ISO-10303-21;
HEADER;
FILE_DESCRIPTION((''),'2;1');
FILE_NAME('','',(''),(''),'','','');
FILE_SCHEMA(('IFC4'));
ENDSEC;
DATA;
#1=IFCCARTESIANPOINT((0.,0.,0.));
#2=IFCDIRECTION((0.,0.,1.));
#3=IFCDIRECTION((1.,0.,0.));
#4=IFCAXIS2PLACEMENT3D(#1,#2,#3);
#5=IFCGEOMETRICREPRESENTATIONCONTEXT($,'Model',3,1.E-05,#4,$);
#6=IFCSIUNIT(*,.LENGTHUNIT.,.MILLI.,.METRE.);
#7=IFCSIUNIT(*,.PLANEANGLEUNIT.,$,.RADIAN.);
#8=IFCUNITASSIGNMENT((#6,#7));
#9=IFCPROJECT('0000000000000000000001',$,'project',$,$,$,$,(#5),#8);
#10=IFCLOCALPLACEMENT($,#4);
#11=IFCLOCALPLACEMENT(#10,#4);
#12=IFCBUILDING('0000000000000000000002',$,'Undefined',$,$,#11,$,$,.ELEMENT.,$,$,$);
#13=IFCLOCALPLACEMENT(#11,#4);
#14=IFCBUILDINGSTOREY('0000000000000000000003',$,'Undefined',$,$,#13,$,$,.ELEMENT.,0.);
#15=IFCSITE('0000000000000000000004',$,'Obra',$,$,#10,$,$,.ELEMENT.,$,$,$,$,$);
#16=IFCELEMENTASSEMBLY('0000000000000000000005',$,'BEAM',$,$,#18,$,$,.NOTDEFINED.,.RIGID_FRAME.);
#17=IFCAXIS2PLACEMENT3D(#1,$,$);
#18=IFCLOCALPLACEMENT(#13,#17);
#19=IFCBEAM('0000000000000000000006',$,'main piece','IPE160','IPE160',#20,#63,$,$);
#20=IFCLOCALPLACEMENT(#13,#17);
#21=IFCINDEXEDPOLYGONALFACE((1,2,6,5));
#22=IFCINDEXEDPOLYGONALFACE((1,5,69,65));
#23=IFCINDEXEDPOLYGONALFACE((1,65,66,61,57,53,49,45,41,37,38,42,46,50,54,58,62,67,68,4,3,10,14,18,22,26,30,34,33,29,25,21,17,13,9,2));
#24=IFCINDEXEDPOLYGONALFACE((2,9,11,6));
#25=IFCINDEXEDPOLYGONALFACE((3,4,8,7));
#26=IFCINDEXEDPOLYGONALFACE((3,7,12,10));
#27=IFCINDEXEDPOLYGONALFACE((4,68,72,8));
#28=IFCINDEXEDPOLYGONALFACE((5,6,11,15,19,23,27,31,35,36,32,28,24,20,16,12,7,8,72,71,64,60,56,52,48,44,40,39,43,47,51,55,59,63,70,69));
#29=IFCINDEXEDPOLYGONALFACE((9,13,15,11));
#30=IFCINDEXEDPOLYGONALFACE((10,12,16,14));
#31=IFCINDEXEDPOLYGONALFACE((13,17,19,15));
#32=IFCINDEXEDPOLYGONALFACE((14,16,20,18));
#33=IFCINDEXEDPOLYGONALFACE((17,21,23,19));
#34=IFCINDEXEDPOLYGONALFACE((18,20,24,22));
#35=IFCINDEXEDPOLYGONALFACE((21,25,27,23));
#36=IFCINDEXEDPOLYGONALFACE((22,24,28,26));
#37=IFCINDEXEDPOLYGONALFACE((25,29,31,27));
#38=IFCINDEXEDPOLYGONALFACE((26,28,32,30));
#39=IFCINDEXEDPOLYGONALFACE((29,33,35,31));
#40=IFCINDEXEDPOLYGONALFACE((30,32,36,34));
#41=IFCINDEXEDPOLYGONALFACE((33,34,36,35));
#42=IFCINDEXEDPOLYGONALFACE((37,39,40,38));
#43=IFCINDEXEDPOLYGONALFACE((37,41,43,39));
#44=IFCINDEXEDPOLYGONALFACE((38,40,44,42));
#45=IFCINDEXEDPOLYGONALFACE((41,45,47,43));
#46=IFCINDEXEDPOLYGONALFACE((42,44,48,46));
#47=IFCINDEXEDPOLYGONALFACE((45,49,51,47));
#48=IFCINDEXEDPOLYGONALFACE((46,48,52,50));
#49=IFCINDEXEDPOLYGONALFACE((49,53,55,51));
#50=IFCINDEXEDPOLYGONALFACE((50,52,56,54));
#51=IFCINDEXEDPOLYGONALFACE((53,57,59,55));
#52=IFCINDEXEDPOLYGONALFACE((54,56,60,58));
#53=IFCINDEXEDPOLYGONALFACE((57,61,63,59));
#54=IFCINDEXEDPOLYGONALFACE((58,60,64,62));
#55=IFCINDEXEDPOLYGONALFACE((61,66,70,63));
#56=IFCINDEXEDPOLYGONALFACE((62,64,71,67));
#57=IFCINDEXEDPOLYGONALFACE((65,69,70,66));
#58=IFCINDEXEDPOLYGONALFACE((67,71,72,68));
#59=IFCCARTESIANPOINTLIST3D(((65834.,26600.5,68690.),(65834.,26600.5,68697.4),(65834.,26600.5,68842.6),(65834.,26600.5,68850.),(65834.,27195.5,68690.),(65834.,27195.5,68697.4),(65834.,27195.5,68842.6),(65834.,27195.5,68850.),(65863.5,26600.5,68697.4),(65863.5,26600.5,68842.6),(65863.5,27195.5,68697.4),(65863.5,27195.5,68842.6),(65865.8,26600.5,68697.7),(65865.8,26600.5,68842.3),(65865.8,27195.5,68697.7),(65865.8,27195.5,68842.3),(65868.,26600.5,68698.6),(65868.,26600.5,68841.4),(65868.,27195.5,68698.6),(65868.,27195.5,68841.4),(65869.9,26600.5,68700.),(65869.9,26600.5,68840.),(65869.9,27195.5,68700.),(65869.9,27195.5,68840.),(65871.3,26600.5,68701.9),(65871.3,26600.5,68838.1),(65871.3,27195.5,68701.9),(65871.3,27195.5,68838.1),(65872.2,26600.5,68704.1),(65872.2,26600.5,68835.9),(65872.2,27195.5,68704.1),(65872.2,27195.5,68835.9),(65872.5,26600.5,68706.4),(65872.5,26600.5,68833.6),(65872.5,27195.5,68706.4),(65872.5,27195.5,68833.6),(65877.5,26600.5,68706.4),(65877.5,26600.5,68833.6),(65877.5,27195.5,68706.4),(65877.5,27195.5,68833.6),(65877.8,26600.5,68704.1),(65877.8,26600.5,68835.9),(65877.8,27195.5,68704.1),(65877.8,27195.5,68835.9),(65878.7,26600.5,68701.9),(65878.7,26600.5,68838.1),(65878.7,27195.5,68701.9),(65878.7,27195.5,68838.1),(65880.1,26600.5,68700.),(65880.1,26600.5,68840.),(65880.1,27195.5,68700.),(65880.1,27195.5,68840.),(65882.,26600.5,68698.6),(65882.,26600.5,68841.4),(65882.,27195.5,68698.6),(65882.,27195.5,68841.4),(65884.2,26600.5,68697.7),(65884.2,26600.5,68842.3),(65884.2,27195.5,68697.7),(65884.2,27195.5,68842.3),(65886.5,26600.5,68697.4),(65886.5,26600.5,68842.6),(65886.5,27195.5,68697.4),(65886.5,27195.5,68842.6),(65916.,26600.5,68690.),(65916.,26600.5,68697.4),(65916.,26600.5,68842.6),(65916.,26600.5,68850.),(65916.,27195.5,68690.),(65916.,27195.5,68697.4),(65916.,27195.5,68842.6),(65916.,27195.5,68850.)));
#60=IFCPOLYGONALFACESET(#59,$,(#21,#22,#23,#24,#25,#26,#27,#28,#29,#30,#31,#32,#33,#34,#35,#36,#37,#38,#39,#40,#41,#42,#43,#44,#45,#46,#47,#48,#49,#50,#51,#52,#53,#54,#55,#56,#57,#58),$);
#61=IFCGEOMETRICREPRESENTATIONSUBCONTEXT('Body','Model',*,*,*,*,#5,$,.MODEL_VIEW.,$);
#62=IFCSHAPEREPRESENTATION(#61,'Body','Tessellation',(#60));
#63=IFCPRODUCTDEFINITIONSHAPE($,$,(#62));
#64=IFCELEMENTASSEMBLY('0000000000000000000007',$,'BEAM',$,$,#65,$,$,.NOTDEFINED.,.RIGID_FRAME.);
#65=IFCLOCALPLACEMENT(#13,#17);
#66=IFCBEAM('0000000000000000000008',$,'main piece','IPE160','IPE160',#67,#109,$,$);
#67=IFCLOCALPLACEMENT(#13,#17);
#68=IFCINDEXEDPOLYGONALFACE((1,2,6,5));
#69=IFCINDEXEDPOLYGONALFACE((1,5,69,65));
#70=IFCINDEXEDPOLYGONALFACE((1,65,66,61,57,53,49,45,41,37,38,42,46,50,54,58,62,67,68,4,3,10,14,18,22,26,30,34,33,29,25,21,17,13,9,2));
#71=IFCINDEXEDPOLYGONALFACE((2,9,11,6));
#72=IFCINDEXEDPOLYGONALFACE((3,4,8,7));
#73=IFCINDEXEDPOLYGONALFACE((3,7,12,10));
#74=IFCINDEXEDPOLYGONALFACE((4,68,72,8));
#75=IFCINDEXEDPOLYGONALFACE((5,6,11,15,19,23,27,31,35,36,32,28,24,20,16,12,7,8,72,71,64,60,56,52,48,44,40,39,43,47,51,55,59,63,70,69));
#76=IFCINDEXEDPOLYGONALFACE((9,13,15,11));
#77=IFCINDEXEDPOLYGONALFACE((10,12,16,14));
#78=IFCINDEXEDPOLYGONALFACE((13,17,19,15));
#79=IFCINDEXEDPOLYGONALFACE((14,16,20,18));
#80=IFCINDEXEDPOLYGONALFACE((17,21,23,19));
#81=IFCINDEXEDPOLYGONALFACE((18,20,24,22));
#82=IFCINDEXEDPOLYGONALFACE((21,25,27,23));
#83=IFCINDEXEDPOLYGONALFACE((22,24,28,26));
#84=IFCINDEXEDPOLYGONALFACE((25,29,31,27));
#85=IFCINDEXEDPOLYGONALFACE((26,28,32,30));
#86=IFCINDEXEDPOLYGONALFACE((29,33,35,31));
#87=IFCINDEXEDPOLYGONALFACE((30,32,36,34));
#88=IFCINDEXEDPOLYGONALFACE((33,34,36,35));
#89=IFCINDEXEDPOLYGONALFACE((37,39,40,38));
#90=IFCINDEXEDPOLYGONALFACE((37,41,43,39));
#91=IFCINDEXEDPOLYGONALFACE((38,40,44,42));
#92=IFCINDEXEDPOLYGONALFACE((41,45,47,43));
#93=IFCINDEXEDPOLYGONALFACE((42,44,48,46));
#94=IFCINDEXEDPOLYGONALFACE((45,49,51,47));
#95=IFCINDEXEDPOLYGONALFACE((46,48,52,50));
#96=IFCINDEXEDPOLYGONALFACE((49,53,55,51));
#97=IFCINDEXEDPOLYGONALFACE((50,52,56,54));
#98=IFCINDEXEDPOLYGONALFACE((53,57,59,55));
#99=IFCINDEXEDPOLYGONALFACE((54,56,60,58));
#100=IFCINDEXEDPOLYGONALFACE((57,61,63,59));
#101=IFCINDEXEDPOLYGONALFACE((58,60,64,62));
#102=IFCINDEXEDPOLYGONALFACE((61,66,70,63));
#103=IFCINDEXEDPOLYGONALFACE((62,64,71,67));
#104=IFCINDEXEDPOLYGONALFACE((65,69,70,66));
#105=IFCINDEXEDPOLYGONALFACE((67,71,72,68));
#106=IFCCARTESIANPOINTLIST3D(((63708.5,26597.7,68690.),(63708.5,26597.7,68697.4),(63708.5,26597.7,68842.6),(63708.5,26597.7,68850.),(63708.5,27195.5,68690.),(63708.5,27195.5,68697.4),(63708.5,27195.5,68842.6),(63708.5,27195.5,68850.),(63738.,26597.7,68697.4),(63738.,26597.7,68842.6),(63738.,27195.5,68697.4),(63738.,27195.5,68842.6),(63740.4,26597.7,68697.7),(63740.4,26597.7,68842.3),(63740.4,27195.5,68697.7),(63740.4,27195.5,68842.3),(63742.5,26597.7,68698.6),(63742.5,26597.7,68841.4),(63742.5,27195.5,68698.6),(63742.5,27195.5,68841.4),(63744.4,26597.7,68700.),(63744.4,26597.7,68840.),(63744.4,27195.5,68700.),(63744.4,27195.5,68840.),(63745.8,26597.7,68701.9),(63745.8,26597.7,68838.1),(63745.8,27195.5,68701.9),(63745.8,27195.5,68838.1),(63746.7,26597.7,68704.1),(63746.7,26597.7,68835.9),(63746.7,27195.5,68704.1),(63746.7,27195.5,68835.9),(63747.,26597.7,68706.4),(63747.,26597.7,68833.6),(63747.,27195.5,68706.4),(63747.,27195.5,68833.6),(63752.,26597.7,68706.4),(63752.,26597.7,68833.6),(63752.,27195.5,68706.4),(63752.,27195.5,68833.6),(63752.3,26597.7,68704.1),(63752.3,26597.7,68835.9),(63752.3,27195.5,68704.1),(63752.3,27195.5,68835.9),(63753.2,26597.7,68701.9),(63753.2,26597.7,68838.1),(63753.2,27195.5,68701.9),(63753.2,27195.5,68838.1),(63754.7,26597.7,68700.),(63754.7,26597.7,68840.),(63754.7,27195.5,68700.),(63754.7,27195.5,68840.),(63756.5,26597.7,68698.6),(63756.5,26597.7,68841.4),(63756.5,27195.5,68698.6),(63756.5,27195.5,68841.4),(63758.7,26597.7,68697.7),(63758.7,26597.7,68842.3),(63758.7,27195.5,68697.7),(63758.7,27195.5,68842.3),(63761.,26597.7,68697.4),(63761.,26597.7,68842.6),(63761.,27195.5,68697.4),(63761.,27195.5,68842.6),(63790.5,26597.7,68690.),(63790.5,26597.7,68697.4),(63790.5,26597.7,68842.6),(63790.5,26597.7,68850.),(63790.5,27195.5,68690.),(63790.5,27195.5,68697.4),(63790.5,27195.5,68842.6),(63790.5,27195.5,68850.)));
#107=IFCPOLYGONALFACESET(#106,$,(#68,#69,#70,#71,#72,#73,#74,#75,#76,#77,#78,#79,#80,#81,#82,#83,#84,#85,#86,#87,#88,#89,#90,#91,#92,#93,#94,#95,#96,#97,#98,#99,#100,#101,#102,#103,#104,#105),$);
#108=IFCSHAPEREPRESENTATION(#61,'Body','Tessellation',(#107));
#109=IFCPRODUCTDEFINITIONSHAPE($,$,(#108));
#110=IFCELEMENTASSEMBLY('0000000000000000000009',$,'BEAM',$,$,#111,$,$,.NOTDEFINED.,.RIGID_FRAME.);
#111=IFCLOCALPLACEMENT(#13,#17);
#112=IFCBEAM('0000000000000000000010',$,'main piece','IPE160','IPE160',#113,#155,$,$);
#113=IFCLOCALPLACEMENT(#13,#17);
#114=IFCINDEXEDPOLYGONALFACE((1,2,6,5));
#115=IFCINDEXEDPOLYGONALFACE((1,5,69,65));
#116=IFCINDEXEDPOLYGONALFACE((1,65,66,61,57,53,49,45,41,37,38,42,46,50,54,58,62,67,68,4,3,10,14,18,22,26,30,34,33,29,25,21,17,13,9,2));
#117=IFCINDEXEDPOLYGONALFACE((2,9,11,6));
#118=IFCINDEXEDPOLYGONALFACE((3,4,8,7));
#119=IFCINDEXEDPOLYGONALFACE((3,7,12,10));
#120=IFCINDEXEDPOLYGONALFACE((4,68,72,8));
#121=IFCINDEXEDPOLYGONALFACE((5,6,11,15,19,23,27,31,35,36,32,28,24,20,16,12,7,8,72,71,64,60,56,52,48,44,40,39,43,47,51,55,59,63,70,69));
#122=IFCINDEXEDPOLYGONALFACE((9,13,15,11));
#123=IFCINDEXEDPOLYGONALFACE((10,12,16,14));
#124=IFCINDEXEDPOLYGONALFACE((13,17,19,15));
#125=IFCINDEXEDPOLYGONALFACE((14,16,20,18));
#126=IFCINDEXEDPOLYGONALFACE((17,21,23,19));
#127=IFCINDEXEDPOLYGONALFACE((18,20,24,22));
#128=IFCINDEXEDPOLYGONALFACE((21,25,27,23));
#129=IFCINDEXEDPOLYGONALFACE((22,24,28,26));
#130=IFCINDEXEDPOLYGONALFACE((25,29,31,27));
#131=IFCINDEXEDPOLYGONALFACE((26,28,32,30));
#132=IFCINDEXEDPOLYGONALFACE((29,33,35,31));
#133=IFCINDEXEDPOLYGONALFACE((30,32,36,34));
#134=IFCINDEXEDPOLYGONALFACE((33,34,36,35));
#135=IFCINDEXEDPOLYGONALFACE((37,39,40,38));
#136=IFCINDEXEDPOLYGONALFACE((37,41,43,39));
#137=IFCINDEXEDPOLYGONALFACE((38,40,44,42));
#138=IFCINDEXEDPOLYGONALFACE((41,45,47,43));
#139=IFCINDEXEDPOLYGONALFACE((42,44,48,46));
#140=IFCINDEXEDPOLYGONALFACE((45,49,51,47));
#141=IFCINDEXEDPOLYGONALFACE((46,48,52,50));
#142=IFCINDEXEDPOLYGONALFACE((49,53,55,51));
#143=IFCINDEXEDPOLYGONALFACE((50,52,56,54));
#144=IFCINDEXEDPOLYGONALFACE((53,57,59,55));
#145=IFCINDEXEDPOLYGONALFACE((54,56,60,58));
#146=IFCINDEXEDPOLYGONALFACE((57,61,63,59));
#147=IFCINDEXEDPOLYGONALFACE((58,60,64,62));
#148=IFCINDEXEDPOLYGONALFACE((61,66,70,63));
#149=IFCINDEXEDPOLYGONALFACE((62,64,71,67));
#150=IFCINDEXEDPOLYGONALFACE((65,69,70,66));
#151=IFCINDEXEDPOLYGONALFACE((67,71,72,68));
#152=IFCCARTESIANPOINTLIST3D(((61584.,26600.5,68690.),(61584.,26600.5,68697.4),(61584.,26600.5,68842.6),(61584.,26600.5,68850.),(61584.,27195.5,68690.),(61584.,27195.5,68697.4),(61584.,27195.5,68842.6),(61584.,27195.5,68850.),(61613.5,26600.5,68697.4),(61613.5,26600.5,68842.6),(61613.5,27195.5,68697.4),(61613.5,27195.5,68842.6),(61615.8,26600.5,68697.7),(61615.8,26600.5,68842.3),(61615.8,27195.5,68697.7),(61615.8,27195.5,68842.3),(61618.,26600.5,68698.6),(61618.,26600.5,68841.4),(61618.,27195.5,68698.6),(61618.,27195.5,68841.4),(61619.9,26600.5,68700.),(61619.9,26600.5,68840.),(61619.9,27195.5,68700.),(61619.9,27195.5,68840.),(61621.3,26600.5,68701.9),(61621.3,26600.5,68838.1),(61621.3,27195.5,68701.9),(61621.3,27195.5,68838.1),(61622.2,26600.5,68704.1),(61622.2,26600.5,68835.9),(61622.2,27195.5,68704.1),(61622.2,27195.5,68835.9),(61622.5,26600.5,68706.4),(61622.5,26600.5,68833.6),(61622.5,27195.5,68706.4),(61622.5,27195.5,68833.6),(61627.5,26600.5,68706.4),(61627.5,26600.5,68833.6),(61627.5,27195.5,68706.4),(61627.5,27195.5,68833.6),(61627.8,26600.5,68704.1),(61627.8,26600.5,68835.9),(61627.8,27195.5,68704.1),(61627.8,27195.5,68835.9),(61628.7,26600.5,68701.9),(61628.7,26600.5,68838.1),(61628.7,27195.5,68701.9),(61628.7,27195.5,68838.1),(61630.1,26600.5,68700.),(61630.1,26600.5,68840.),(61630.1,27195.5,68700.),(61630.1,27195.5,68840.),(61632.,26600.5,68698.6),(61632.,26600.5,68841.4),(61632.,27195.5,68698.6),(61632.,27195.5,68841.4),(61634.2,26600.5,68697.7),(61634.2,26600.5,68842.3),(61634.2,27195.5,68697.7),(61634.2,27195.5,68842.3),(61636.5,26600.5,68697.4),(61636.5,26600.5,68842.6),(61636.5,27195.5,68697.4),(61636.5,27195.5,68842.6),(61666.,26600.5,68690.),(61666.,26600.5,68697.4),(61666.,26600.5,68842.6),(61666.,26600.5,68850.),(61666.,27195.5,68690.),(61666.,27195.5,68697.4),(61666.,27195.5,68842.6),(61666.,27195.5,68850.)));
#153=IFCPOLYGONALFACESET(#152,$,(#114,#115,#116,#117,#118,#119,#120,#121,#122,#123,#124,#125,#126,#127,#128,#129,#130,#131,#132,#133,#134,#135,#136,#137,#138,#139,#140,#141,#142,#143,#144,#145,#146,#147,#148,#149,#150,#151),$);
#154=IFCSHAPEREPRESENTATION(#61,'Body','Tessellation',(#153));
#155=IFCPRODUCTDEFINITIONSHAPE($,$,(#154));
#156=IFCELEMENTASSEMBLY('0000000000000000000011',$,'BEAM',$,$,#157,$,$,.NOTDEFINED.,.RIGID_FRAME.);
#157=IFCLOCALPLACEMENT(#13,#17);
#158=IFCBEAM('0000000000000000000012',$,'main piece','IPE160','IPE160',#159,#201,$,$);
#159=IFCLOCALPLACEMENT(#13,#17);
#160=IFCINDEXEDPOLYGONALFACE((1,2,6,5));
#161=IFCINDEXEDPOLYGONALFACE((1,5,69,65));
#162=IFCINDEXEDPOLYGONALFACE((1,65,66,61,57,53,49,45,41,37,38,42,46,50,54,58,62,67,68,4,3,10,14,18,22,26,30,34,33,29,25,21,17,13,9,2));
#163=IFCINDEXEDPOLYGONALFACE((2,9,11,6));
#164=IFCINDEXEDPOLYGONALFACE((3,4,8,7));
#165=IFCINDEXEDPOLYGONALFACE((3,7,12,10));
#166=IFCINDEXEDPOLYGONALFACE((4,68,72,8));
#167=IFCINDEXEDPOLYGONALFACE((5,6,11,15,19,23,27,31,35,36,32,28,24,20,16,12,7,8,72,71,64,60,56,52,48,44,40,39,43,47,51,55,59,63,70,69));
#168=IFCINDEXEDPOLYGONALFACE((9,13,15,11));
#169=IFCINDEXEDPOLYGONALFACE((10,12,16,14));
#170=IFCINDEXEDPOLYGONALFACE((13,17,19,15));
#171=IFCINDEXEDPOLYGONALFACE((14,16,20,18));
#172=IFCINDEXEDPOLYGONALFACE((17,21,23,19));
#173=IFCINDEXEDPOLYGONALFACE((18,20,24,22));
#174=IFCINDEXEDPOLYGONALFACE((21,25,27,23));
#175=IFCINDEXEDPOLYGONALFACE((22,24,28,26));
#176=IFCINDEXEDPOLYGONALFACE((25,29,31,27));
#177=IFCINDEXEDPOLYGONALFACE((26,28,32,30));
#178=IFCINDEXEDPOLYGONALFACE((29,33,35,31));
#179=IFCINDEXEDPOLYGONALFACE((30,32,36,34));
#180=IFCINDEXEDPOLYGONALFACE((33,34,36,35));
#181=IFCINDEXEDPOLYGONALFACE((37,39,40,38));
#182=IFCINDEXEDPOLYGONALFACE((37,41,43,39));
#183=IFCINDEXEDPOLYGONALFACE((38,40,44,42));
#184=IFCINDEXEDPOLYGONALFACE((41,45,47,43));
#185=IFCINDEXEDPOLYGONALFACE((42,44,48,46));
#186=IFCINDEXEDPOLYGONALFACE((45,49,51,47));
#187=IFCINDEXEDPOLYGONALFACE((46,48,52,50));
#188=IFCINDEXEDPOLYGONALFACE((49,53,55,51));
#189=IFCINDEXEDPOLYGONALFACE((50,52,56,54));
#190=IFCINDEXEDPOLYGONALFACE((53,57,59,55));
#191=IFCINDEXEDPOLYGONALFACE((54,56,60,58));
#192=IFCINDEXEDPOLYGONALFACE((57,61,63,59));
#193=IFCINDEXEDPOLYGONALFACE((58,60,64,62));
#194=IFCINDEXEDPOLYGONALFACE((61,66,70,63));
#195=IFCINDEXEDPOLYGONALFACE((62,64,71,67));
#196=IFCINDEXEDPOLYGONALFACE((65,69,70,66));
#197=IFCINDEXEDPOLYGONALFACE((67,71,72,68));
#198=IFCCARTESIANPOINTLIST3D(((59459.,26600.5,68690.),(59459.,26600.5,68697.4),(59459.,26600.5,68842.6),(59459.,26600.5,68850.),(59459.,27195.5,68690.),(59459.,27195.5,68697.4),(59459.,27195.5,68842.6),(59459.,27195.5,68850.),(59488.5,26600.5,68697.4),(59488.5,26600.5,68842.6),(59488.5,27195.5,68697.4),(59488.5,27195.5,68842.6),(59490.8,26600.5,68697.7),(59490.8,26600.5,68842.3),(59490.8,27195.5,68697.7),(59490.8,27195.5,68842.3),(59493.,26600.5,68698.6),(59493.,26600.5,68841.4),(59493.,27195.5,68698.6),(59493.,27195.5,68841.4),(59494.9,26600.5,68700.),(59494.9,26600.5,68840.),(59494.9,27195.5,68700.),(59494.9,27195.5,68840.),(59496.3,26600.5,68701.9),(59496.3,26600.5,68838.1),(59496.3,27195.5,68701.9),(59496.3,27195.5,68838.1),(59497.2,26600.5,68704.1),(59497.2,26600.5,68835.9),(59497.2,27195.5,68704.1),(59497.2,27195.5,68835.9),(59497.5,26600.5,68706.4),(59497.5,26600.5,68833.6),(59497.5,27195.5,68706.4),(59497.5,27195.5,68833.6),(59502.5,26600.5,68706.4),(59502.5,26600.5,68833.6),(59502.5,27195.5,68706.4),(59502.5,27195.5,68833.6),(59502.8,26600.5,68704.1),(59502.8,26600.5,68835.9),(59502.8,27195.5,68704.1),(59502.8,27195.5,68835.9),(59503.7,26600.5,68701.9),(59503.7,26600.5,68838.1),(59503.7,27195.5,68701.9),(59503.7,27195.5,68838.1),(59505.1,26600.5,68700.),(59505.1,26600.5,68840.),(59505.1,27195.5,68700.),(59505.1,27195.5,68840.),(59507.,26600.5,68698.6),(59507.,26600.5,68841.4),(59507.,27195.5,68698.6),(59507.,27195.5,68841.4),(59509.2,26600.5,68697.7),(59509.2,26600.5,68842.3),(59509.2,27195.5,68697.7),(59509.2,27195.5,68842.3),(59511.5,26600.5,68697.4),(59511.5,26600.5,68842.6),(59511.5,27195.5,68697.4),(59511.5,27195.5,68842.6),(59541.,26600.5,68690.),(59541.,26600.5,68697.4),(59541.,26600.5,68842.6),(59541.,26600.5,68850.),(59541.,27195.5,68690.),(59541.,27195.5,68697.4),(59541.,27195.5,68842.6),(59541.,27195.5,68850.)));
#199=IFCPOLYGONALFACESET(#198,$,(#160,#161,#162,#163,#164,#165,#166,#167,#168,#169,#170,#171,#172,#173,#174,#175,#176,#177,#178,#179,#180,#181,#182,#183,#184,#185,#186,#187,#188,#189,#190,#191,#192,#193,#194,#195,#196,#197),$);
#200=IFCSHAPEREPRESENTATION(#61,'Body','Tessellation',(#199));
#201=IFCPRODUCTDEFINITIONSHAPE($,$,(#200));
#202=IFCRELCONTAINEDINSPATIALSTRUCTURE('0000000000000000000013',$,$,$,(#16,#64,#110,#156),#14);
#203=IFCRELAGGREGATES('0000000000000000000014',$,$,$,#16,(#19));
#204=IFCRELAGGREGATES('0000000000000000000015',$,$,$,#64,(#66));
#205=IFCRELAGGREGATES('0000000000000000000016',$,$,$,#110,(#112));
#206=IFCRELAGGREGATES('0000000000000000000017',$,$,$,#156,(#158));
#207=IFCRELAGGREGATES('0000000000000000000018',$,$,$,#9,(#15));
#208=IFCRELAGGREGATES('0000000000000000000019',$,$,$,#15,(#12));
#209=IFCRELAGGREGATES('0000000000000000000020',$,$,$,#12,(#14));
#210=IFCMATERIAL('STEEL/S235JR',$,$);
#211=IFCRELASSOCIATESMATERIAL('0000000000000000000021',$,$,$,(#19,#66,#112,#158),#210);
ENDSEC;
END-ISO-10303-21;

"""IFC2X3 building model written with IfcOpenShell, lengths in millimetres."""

from ifc_helpers import new_model, si_unit, frame, origin_with_axes, origin_2d_with_axis, place, context, subcontext, project, spatial, i_section, extrude, material, element, aggregate, save


model = new_model("IFC2X3")

# Units and contexts
model_context = context("Model", 3, precision=1e-05, world=origin_with_axes())
body_context = subcontext(model_context, "Body", "Model", "MODEL_VIEW")
ifc_project = project(units=[si_unit("LENGTHUNIT", "METRE", prefix="MILLI"), si_unit("PLANEANGLEUNIT", "RADIAN")], contexts=[model_context])

# Site, building, storey
site_placement = place(None, origin_with_axes())
site = spatial("IfcSite", under=ifc_project, at=site_placement, Name="Obra", CompositionType="ELEMENT")
building_placement = place(site_placement, origin_with_axes())
building = spatial("IfcBuilding", under=site, at=building_placement, Name="Undefined", CompositionType="ELEMENT")
storey_placement = place(building_placement, origin_with_axes())
storey = spatial("IfcBuildingStorey", under=building, at=storey_placement, Name="Undefined", CompositionType="ELEMENT", Elevation=0.0)

# Element assemblies, beams
assembly_1_placement = place(storey_placement, origin_with_axes())
assembly_1 = element("IfcElementAssembly", 1, at=assembly_1_placement, inside=storey, Name="BEAM", AssemblyPlace="NOTDEFINED", PredefinedType="RIGID_FRAME")
ifc_material_1 = material(Name="STEEL/S235JR")
beam_1_placement = place(assembly_1_placement, frame((65875.0, 26600.5, 68770.0), z_axis=(0.0, 0.0, 1.0), x_axis=(0.0, 1.0, 0.0)))
beam_1 = element("IfcBeam", 2, at=beam_1_placement, material=ifc_material_1, Name="main piece", Description="IPE160", ObjectType="IPE160", context=body_context, shape_type="SweptSolid", body=[
    extrude(i_section(OverallWidth=82.0, OverallDepth=160.0, WebThickness=5.0, FlangeThickness=7.4, FilletRadius=9.0, at=origin_2d_with_axis()), frame((595.1, 0.0, 0.0), z_axis=(-1.0, 0.0, 0.0), x_axis=(0.0, -1.0, 0.0)), (0.0, 0.0, 1.0), 595.0),
])
aggregate(assembly_1, [beam_1])
assembly_2_placement = place(storey_placement, origin_with_axes())
assembly_2 = element("IfcElementAssembly", 3, at=assembly_2_placement, inside=storey, Name="BEAM", AssemblyPlace="NOTDEFINED", PredefinedType="RIGID_FRAME")
beam_2_placement = place(assembly_2_placement, frame((63749.5, 26597.7, 68770.0), z_axis=(0.0, 0.0, 1.0), x_axis=(0.0, 1.0, 0.0)))
beam_2 = element("IfcBeam", 4, at=beam_2_placement, material=ifc_material_1, Name="main piece", Description="IPE160", ObjectType="IPE160", context=body_context, shape_type="SweptSolid", body=[
    extrude(i_section(OverallWidth=82.0, OverallDepth=160.0, WebThickness=5.0, FlangeThickness=7.4, FilletRadius=9.0, at=origin_2d_with_axis()), frame((597.8, 0.0, 0.0), z_axis=(-1.0, 0.0, 0.0), x_axis=(0.0, -1.0, 0.0)), (0.0, 0.0, 1.0), 597.8),
])
aggregate(assembly_2, [beam_2])
assembly_3_placement = place(storey_placement, origin_with_axes())
assembly_3 = element("IfcElementAssembly", 5, at=assembly_3_placement, inside=storey, Name="BEAM", AssemblyPlace="NOTDEFINED", PredefinedType="RIGID_FRAME")
beam_3_placement = place(assembly_3_placement, frame((61625.0, 27195.5, 68770.0), z_axis=(0.0, 0.0, 1.0), x_axis=(0.0, -1.0, 0.0)))
beam_3 = element("IfcBeam", 6, at=beam_3_placement, material=ifc_material_1, Name="main piece", Description="IPE160", ObjectType="IPE160", context=body_context, shape_type="SweptSolid", body=[
    extrude(i_section(OverallWidth=82.0, OverallDepth=160.0, WebThickness=5.0, FlangeThickness=7.4, FilletRadius=9.0, at=origin_2d_with_axis()), frame((595.0, 0.0, 0.0), z_axis=(-1.0, 0.0, 0.0), x_axis=(0.0, -1.0, 0.0)), (0.0, 0.0, 1.0), 595.0),
])
aggregate(assembly_3, [beam_3])
assembly_4_placement = place(storey_placement, origin_with_axes())
assembly_4 = element("IfcElementAssembly", 7, at=assembly_4_placement, inside=storey, Name="BEAM", AssemblyPlace="NOTDEFINED", PredefinedType="RIGID_FRAME")
beam_4_placement = place(assembly_4_placement, frame((59500.0, 26600.5, 68770.0), z_axis=(0.0, 0.0, 1.0), x_axis=(0.0, 1.0, 0.0)))
beam_4 = element("IfcBeam", 8, at=beam_4_placement, material=ifc_material_1, Name="main piece", Description="IPE160", ObjectType="IPE160", context=body_context, shape_type="SweptSolid", body=[
    extrude(i_section(OverallWidth=82.0, OverallDepth=160.0, WebThickness=5.0, FlangeThickness=7.4, FilletRadius=9.0, at=origin_2d_with_axis()), frame((595.0, 0.0, 0.0), z_axis=(-1.0, 0.0, 0.0), x_axis=(0.0, -1.0, 0.0)), (0.0, 0.0, 1.0), 595.0),
])
aggregate(assembly_4, [beam_4])

save(model, "model.ifc")
